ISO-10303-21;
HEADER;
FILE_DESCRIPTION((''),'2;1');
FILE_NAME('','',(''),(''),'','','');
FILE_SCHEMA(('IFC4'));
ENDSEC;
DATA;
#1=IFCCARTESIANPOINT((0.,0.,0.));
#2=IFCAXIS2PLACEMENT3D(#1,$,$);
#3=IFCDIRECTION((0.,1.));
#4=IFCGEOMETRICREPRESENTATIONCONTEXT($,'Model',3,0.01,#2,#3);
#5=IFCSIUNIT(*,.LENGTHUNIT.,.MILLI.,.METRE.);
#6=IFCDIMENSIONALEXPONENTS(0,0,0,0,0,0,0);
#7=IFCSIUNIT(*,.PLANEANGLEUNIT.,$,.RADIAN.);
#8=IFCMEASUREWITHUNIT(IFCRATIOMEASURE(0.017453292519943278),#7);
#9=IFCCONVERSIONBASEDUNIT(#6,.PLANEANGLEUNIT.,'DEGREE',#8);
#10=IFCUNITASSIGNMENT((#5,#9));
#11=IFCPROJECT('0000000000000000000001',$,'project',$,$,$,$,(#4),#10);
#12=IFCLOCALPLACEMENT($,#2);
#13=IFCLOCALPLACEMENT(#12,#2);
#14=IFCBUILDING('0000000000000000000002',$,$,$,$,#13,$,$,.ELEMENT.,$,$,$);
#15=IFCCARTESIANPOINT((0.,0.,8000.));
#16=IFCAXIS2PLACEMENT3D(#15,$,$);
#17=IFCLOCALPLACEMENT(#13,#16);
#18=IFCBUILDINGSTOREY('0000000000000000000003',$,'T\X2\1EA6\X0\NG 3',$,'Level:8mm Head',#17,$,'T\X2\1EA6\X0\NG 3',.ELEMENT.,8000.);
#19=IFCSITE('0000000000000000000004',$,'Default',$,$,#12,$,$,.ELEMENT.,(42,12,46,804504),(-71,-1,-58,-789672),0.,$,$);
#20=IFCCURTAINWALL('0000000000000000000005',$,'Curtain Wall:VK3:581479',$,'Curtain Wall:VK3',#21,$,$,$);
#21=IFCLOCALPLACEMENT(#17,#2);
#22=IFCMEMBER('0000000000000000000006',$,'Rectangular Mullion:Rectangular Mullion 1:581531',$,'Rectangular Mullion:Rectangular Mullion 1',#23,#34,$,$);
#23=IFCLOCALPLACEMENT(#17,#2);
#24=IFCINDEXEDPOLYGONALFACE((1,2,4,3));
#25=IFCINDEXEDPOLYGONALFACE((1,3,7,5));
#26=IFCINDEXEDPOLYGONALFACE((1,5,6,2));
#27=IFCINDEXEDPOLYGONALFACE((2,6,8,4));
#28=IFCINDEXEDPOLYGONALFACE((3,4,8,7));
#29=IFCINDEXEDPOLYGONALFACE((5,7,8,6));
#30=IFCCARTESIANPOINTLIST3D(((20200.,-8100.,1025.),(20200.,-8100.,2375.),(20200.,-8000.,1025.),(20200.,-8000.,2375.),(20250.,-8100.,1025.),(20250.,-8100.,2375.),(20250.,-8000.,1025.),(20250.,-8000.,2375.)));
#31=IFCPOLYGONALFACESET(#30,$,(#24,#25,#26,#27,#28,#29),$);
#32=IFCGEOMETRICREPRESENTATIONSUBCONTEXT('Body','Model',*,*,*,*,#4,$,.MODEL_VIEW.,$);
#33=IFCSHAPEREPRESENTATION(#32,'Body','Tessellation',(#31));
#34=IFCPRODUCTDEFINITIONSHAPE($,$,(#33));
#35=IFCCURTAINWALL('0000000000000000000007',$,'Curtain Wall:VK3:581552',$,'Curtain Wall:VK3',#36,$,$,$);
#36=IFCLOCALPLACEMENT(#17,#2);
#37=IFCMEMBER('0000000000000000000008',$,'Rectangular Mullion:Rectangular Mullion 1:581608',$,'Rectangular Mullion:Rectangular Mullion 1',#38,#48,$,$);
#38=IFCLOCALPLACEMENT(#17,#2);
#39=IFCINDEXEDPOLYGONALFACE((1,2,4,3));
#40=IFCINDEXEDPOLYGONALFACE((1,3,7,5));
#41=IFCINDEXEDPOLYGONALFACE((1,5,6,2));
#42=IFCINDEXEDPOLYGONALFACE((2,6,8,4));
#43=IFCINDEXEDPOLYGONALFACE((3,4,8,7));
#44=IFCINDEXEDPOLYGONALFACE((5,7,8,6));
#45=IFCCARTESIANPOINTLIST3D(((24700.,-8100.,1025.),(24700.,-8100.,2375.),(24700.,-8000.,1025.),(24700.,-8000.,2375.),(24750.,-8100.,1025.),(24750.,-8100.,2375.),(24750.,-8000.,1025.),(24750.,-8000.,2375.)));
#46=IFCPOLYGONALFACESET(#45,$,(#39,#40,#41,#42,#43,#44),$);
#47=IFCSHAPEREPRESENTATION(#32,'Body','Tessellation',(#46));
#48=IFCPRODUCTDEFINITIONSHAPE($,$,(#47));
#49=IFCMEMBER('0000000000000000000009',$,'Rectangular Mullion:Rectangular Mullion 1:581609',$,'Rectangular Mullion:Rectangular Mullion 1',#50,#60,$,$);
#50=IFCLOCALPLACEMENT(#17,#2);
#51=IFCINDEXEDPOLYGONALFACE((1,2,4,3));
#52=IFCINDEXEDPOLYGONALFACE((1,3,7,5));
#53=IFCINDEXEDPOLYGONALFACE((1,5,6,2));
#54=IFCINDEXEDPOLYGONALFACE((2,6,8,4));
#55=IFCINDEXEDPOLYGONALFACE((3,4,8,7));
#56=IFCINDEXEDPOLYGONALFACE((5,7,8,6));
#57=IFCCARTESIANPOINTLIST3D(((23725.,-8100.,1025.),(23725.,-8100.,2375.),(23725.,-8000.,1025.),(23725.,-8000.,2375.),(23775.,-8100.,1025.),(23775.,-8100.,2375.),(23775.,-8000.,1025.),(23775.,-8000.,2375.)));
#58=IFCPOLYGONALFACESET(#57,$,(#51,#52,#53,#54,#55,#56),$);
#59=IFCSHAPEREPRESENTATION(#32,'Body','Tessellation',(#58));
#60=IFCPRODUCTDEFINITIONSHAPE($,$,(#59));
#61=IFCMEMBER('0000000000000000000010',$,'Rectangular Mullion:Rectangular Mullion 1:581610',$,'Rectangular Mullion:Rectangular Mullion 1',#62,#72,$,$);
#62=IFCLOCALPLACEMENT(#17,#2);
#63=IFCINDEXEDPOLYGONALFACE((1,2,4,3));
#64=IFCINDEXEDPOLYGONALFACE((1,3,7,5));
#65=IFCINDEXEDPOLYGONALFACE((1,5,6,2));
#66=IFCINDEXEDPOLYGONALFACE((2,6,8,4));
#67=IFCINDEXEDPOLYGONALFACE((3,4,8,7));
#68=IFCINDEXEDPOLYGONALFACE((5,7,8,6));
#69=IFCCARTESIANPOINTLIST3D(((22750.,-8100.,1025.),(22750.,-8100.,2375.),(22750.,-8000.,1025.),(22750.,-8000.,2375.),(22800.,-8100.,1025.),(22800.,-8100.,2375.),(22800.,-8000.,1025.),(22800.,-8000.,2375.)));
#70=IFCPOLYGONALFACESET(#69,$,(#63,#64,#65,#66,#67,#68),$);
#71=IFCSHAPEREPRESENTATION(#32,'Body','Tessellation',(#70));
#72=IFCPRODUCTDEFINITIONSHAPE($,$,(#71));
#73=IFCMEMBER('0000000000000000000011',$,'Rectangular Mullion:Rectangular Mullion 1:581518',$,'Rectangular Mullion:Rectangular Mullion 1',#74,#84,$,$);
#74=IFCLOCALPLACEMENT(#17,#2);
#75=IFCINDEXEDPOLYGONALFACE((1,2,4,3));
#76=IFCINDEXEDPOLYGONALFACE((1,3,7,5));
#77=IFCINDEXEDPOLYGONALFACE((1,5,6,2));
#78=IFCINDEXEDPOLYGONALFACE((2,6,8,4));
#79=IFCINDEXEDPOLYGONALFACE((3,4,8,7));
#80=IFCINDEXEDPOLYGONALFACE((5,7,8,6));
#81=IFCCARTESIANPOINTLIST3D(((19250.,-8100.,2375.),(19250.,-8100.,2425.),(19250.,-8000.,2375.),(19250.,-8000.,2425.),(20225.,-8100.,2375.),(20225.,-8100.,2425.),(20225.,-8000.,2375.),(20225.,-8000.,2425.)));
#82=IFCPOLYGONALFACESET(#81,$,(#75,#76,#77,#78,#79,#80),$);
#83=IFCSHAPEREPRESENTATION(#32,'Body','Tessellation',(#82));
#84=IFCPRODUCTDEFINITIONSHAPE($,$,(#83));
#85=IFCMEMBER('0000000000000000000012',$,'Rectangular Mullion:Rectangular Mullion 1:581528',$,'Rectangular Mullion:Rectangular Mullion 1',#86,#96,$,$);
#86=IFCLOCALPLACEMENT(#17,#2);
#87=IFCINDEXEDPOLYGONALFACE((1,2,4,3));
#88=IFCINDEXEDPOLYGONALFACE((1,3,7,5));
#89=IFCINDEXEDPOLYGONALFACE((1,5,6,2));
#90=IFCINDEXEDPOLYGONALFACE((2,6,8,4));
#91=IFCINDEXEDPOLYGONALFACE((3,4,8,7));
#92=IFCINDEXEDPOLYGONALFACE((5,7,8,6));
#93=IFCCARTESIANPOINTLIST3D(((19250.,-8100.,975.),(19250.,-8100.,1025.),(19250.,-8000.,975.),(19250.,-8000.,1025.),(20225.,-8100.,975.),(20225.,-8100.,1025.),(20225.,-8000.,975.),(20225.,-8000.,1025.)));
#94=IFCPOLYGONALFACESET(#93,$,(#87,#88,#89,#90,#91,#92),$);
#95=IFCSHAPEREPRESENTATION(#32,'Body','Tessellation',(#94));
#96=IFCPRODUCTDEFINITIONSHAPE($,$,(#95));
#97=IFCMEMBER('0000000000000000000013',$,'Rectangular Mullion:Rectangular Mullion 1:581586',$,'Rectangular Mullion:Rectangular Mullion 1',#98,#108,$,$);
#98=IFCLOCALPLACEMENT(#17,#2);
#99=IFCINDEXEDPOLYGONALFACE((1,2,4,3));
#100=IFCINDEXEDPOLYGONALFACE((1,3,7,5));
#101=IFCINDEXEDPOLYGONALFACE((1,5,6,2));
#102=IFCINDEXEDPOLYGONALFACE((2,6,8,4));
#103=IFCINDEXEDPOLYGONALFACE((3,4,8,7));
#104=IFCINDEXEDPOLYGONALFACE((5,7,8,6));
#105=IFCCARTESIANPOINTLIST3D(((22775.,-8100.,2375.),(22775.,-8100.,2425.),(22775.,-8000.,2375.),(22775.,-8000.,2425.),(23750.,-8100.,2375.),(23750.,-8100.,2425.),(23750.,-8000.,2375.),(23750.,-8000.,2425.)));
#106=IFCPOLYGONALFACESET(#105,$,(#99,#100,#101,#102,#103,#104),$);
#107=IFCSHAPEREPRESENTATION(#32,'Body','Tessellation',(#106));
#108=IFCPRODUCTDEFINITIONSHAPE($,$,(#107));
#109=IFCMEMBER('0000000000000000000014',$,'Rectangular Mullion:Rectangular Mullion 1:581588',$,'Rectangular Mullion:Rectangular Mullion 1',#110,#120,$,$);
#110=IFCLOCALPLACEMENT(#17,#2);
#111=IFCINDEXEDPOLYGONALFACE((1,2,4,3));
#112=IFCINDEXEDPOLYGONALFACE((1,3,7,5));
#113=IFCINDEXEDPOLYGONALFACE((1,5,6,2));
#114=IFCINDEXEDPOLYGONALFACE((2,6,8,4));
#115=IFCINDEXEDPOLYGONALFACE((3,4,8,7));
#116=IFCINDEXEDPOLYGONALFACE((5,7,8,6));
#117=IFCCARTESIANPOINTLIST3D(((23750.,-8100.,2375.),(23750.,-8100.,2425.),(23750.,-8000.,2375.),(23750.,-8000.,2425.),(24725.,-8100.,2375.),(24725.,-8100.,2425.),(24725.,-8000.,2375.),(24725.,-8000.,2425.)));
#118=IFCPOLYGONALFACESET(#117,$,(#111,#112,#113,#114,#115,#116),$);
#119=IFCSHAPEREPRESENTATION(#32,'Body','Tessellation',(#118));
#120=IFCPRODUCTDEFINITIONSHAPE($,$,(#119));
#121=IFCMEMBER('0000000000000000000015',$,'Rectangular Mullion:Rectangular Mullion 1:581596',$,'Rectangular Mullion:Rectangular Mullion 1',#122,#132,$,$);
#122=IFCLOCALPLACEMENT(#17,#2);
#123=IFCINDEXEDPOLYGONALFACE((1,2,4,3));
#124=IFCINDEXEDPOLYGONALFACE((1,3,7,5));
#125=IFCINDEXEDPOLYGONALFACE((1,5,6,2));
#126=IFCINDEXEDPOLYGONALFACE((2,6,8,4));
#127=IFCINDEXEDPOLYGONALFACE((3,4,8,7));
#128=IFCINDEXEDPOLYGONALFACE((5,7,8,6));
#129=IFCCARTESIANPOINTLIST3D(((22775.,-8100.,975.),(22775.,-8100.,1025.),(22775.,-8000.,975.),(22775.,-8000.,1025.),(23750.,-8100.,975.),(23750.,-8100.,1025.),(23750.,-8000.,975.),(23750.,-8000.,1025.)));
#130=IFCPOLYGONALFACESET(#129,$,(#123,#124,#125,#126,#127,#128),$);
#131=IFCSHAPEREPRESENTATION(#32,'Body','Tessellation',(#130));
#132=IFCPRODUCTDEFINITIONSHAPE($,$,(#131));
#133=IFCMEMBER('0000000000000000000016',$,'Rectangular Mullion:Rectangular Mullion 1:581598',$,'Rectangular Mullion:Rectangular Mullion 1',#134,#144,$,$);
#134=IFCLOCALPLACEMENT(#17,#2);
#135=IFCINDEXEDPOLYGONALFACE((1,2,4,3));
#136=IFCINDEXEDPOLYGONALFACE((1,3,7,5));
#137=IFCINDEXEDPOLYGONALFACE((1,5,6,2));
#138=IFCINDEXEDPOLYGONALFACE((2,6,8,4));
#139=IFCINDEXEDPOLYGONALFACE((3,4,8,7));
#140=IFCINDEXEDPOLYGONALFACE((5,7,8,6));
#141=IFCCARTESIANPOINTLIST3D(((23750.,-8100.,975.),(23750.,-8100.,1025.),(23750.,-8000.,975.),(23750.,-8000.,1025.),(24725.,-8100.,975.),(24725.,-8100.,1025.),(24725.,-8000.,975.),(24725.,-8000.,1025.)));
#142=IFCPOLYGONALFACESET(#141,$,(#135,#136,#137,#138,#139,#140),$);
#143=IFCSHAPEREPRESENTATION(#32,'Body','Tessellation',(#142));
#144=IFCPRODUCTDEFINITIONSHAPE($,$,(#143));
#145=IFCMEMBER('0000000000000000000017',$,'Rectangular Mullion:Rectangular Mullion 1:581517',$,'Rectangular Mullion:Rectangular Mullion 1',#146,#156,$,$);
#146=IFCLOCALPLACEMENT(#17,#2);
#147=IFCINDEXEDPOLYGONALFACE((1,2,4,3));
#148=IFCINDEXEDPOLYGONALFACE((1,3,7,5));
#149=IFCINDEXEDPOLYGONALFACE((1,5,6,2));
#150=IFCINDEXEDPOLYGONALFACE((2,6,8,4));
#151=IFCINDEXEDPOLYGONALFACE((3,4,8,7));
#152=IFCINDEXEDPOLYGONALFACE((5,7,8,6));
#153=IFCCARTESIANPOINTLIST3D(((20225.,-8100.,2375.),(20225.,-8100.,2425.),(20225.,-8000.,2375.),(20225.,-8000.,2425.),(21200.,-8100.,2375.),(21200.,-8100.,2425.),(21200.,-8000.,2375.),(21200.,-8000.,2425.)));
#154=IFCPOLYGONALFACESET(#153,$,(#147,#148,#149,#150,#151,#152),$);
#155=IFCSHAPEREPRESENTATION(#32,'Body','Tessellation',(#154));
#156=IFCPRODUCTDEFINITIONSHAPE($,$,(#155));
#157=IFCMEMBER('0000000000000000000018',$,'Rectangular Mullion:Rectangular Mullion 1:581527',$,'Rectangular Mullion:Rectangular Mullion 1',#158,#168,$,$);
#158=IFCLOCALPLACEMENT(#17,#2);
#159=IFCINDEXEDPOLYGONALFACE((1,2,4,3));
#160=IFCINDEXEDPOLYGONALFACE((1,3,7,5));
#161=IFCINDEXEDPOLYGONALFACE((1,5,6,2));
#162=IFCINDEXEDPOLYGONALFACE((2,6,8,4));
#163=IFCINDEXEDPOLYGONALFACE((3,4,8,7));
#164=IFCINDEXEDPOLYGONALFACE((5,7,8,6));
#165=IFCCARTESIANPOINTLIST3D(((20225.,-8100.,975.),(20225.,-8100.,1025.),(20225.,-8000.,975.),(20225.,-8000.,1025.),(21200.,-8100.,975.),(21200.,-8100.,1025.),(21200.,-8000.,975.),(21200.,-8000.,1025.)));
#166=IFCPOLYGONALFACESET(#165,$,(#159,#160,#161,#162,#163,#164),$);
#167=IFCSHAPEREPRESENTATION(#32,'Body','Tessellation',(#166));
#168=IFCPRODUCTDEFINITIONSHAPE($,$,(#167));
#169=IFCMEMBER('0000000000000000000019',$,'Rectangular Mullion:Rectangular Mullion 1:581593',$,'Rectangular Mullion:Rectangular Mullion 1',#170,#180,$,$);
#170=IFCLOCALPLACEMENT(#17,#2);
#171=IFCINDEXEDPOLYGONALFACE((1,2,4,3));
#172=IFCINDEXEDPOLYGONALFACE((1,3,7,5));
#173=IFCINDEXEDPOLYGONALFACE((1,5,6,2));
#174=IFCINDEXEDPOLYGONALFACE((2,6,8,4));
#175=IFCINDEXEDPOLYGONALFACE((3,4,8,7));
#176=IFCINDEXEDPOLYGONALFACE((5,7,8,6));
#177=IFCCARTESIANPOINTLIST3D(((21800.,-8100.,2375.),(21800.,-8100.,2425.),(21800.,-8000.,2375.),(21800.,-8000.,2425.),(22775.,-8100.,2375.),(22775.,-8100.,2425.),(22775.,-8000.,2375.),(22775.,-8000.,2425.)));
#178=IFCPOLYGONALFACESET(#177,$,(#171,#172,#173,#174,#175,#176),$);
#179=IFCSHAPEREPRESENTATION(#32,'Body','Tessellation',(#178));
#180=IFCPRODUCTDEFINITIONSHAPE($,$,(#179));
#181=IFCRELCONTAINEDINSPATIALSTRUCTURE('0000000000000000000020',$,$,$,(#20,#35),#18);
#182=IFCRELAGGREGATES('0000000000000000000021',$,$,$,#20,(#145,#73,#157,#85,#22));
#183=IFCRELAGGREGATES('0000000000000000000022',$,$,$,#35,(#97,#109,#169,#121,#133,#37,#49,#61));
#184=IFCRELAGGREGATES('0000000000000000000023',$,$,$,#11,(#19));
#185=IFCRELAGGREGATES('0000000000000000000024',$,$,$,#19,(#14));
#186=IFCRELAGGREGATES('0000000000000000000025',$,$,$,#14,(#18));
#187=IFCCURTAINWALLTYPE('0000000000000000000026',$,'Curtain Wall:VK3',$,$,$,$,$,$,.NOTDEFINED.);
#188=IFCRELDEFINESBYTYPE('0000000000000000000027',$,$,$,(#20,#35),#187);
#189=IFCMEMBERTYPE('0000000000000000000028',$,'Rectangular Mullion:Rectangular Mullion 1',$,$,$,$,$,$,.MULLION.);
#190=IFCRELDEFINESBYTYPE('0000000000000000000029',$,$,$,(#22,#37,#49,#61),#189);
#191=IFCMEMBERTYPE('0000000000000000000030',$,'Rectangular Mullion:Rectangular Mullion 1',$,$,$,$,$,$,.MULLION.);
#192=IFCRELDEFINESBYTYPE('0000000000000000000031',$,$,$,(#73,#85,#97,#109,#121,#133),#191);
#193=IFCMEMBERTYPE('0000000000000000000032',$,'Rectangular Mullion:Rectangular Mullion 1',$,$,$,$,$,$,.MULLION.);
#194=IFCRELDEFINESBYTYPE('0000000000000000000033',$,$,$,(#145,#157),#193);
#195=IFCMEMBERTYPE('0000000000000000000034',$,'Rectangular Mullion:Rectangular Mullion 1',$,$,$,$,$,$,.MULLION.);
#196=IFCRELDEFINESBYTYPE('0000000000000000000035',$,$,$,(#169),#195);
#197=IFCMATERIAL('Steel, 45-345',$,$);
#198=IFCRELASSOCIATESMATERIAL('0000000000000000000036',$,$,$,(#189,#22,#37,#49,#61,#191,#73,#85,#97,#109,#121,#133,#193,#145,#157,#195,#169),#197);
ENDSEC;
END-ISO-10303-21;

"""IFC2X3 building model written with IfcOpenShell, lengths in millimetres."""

from ifc_helpers import new_model, entity, si_unit, converted_unit, direction, frame, origin, origin_2d_with_axis, place, context, subcontext, project, spatial, rectangle, extrude, source, transform, mapped, material, type_object, type_shapes, element, aggregate, save


model = new_model("IFC2X3")

# Units and contexts
model_context = context("Model", 3, precision=0.01, world=origin(), true_north=direction((0.0, 1.0)))
body_context = subcontext(model_context, "Body", "Model", "MODEL_VIEW")
ifc_project = project(units=[si_unit("LENGTHUNIT", "METRE", prefix="MILLI"), converted_unit("PLANEANGLEUNIT", "DEGREE", entity("IfcRatioMeasure", 0.017453292519943278), si_unit("PLANEANGLEUNIT", "RADIAN"), dimensions=[0, 0, 0, 0, 0, 0, 0])], contexts=[model_context])

# Site, building, storey
site_placement = place(None, origin())
site = spatial("IfcSite", under=ifc_project, at=site_placement, Name="Default", CompositionType="ELEMENT", RefLatitude=(42, 12, 46, 804504), RefLongitude=(-71, -1, -58, -789672), RefElevation=0.0)
building_placement = place(site_placement, origin())
building = spatial("IfcBuilding", under=site, at=building_placement, CompositionType="ELEMENT")
storey_placement = place(building_placement, frame((0.0, 0.0, 8000.0)))
storey = spatial("IfcBuildingStorey", under=building, at=storey_placement, Name="TẦNG 3", ObjectType="Level:8mm Head", LongName="TẦNG 3", CompositionType="ELEMENT", Elevation=8000.0)

# Curtain wall, member
curtain_wall_type = type_object("IfcCurtainWallType", Name="Curtain Wall:VK3", PredefinedType="NOTDEFINED")
curtain_wall_1_placement = place(storey_placement, frame((0.0, 0.0, -8000.0)))
curtain_wall_1 = element("IfcCurtainWall", 1, at=curtain_wall_1_placement, inside=storey, type_object=curtain_wall_type, Name="Curtain Wall:VK3:581479", ObjectType="Curtain Wall:VK3")
ifc_material_1 = material(Name="Steel, 45-345")
member_type_1 = type_object("IfcMemberType", Name="Rectangular Mullion:Rectangular Mullion 1", PredefinedType="MULLION", material=ifc_material_1)
shared_shape_1 = source(origin(), body_context, "Body", "SweptSolid", [
    extrude(rectangle(XDim=100.0, YDim=50.0, at=origin_2d_with_axis()), frame((0.0, 50.0, -1350.0), z_axis=(0.0, 0.0, 1.0), x_axis=(0.0, -1.0, 0.0)), (0.0, 0.0, 1.0), 1350.0),
])
type_shapes(member_type_1, [shared_shape_1])
member_1_placement = place(curtain_wall_1_placement, frame((20225.0, -8000.0, 9025.0), z_axis=(0.0, 0.0, -1.0), x_axis=(1.0, 0.0, 0.0)))
member_1 = element("IfcMember", 2, at=member_1_placement, type_object=member_type_1, material=ifc_material_1, Name="Rectangular Mullion:Rectangular Mullion 1:581531", ObjectType="Rectangular Mullion:Rectangular Mullion 1", context=body_context, shape_type="MappedRepresentation", body=[
    mapped(shared_shape_1, transform((0.0, 0.0, 0.0), scale=1.0)),
])

# Curtain wall, members
curtain_wall_2_placement = place(storey_placement, frame((0.0, 0.0, -8000.0)))
curtain_wall_2 = element("IfcCurtainWall", 3, at=curtain_wall_2_placement, inside=storey, type_object=curtain_wall_type, Name="Curtain Wall:VK3:581552", ObjectType="Curtain Wall:VK3")
member_2_placement = place(curtain_wall_2_placement, frame((24725.0, -8000.0, 9025.0), z_axis=(0.0, 0.0, -1.0), x_axis=(1.0, 0.0, 0.0)))
member_2 = element("IfcMember", 4, at=member_2_placement, type_object=member_type_1, material=ifc_material_1, Name="Rectangular Mullion:Rectangular Mullion 1:581608", ObjectType="Rectangular Mullion:Rectangular Mullion 1", context=body_context, shape_type="MappedRepresentation", body=[
    mapped(shared_shape_1, transform((0.0, 0.0, 0.0), scale=1.0)),
])
member_3_placement = place(curtain_wall_2_placement, frame((23750.0, -8000.0, 9025.0), z_axis=(0.0, 0.0, -1.0), x_axis=(1.0, 0.0, 0.0)))
member_3 = element("IfcMember", 5, at=member_3_placement, type_object=member_type_1, material=ifc_material_1, Name="Rectangular Mullion:Rectangular Mullion 1:581609", ObjectType="Rectangular Mullion:Rectangular Mullion 1", context=body_context, shape_type="MappedRepresentation", body=[
    mapped(shared_shape_1, transform((0.0, 0.0, 0.0), scale=1.0)),
])
member_4_placement = place(curtain_wall_2_placement, frame((22775.0, -8000.0, 9025.0), z_axis=(0.0, 0.0, -1.0), x_axis=(1.0, 0.0, 0.0)))
member_4 = element("IfcMember", 6, at=member_4_placement, type_object=member_type_1, material=ifc_material_1, Name="Rectangular Mullion:Rectangular Mullion 1:581610", ObjectType="Rectangular Mullion:Rectangular Mullion 1", context=body_context, shape_type="MappedRepresentation", body=[
    mapped(shared_shape_1, transform((0.0, 0.0, 0.0), scale=1.0)),
])

# Members
member_type_2 = type_object("IfcMemberType", Name="Rectangular Mullion:Rectangular Mullion 1", PredefinedType="MULLION", material=ifc_material_1)
shared_shape_2 = source(origin(), body_context, "Body", "SweptSolid", [
    extrude(rectangle(XDim=100.0, YDim=50.0, at=origin_2d_with_axis()), frame((0.0, 50.0, -975.0), z_axis=(0.0, 0.0, 1.0), x_axis=(0.0, -1.0, 0.0)), (0.0, 0.0, 1.0), 975.0),
])
type_shapes(member_type_2, [shared_shape_2])
member_5_placement = place(curtain_wall_1_placement, frame((20225.0, -8000.0, 10400.0), z_axis=(1.0, 0.0, 0.0), x_axis=(0.0, 0.0, 1.0)))
member_5 = element("IfcMember", 7, at=member_5_placement, type_object=member_type_2, material=ifc_material_1, Name="Rectangular Mullion:Rectangular Mullion 1:581518", ObjectType="Rectangular Mullion:Rectangular Mullion 1", context=body_context, shape_type="MappedRepresentation", body=[
    mapped(shared_shape_2, transform((0.0, 0.0, 0.0), scale=1.0)),
])
member_6_placement = place(curtain_wall_1_placement, frame((20225.0, -8000.0, 9000.0), z_axis=(1.0, 0.0, 0.0), x_axis=(0.0, 0.0, 1.0)))
member_6 = element("IfcMember", 8, at=member_6_placement, type_object=member_type_2, material=ifc_material_1, Name="Rectangular Mullion:Rectangular Mullion 1:581528", ObjectType="Rectangular Mullion:Rectangular Mullion 1", context=body_context, shape_type="MappedRepresentation", body=[
    mapped(shared_shape_2, transform((0.0, 0.0, 0.0), scale=1.0)),
])
member_7_placement = place(curtain_wall_2_placement, frame((23750.0, -8000.0, 10400.0), z_axis=(1.0, 0.0, 0.0), x_axis=(0.0, 0.0, 1.0)))
member_7 = element("IfcMember", 9, at=member_7_placement, type_object=member_type_2, material=ifc_material_1, Name="Rectangular Mullion:Rectangular Mullion 1:581586", ObjectType="Rectangular Mullion:Rectangular Mullion 1", context=body_context, shape_type="MappedRepresentation", body=[
    mapped(shared_shape_2, transform((0.0, 0.0, 0.0), scale=1.0)),
])
member_8_placement = place(curtain_wall_2_placement, frame((24725.0, -8000.0, 10400.0), z_axis=(1.0, 0.0, 0.0), x_axis=(0.0, 0.0, 1.0)))
member_8 = element("IfcMember", 10, at=member_8_placement, type_object=member_type_2, material=ifc_material_1, Name="Rectangular Mullion:Rectangular Mullion 1:581588", ObjectType="Rectangular Mullion:Rectangular Mullion 1", context=body_context, shape_type="MappedRepresentation", body=[
    mapped(shared_shape_2, transform((0.0, 0.0, 0.0), scale=1.0)),
])
member_9_placement = place(curtain_wall_2_placement, frame((23750.0, -8000.0, 9000.0), z_axis=(1.0, 0.0, 0.0), x_axis=(0.0, 0.0, 1.0)))
member_9 = element("IfcMember", 11, at=member_9_placement, type_object=member_type_2, material=ifc_material_1, Name="Rectangular Mullion:Rectangular Mullion 1:581596", ObjectType="Rectangular Mullion:Rectangular Mullion 1", context=body_context, shape_type="MappedRepresentation", body=[
    mapped(shared_shape_2, transform((0.0, 0.0, 0.0), scale=1.0)),
])
member_10_placement = place(curtain_wall_2_placement, frame((24725.0, -8000.0, 9000.0), z_axis=(1.0, 0.0, 0.0), x_axis=(0.0, 0.0, 1.0)))
member_10 = element("IfcMember", 12, at=member_10_placement, type_object=member_type_2, material=ifc_material_1, Name="Rectangular Mullion:Rectangular Mullion 1:581598", ObjectType="Rectangular Mullion:Rectangular Mullion 1", context=body_context, shape_type="MappedRepresentation", body=[
    mapped(shared_shape_2, transform((0.0, 0.0, 0.0), scale=1.0)),
])
member_type_3 = type_object("IfcMemberType", Name="Rectangular Mullion:Rectangular Mullion 1", PredefinedType="MULLION", material=ifc_material_1)
shared_shape_3 = source(origin(), body_context, "Body", "SweptSolid", [
    extrude(rectangle(XDim=100.0, YDim=50.0, at=origin_2d_with_axis()), frame((0.0, 50.0, -975.0), z_axis=(0.0, 0.0, 1.0), x_axis=(0.0, -1.0, 0.0)), (0.0, 0.0, 1.0), 975.0),
])
type_shapes(member_type_3, [shared_shape_3])
member_11_placement = place(curtain_wall_1_placement, frame((21200.0, -8000.0, 10400.0), z_axis=(1.0, 0.0, 0.0), x_axis=(0.0, 0.0, 1.0)))
member_11 = element("IfcMember", 13, at=member_11_placement, type_object=member_type_3, material=ifc_material_1, Name="Rectangular Mullion:Rectangular Mullion 1:581517", ObjectType="Rectangular Mullion:Rectangular Mullion 1", context=body_context, shape_type="MappedRepresentation", body=[
    mapped(shared_shape_3, transform((0.0, 0.0, 0.0), scale=1.0)),
])
member_12_placement = place(curtain_wall_1_placement, frame((21200.0, -8000.0, 9000.0), z_axis=(1.0, 0.0, 0.0), x_axis=(0.0, 0.0, 1.0)))
member_12 = element("IfcMember", 14, at=member_12_placement, type_object=member_type_3, material=ifc_material_1, Name="Rectangular Mullion:Rectangular Mullion 1:581527", ObjectType="Rectangular Mullion:Rectangular Mullion 1", context=body_context, shape_type="MappedRepresentation", body=[
    mapped(shared_shape_3, transform((0.0, 0.0, 0.0), scale=1.0)),
])
member_type_4 = type_object("IfcMemberType", Name="Rectangular Mullion:Rectangular Mullion 1", PredefinedType="MULLION", material=ifc_material_1)
shared_shape_4 = source(origin(), body_context, "Body", "SweptSolid", [
    extrude(rectangle(XDim=100.0, YDim=50.0, at=origin_2d_with_axis()), frame((0.0, 50.0, -975.0), z_axis=(0.0, 0.0, 1.0), x_axis=(0.0, -1.0, 0.0)), (0.0, 0.0, 1.0), 975.0),
])
type_shapes(member_type_4, [shared_shape_4])
member_13_placement = place(curtain_wall_2_placement, frame((22775.0, -8000.0, 10400.0), z_axis=(1.0, 0.0, 0.0), x_axis=(0.0, 0.0, 1.0)))
member_13 = element("IfcMember", 15, at=member_13_placement, type_object=member_type_4, material=ifc_material_1, Name="Rectangular Mullion:Rectangular Mullion 1:581593", ObjectType="Rectangular Mullion:Rectangular Mullion 1", context=body_context, shape_type="MappedRepresentation", body=[
    mapped(shared_shape_4, transform((0.0, 0.0, 0.0), scale=1.0)),
])

aggregate(curtain_wall_1, [member_11, member_5, member_12, member_6, member_1])
aggregate(curtain_wall_2, [member_7, member_8, member_13, member_9, member_10, member_2, member_3, member_4])

save(model, "model.ifc")
